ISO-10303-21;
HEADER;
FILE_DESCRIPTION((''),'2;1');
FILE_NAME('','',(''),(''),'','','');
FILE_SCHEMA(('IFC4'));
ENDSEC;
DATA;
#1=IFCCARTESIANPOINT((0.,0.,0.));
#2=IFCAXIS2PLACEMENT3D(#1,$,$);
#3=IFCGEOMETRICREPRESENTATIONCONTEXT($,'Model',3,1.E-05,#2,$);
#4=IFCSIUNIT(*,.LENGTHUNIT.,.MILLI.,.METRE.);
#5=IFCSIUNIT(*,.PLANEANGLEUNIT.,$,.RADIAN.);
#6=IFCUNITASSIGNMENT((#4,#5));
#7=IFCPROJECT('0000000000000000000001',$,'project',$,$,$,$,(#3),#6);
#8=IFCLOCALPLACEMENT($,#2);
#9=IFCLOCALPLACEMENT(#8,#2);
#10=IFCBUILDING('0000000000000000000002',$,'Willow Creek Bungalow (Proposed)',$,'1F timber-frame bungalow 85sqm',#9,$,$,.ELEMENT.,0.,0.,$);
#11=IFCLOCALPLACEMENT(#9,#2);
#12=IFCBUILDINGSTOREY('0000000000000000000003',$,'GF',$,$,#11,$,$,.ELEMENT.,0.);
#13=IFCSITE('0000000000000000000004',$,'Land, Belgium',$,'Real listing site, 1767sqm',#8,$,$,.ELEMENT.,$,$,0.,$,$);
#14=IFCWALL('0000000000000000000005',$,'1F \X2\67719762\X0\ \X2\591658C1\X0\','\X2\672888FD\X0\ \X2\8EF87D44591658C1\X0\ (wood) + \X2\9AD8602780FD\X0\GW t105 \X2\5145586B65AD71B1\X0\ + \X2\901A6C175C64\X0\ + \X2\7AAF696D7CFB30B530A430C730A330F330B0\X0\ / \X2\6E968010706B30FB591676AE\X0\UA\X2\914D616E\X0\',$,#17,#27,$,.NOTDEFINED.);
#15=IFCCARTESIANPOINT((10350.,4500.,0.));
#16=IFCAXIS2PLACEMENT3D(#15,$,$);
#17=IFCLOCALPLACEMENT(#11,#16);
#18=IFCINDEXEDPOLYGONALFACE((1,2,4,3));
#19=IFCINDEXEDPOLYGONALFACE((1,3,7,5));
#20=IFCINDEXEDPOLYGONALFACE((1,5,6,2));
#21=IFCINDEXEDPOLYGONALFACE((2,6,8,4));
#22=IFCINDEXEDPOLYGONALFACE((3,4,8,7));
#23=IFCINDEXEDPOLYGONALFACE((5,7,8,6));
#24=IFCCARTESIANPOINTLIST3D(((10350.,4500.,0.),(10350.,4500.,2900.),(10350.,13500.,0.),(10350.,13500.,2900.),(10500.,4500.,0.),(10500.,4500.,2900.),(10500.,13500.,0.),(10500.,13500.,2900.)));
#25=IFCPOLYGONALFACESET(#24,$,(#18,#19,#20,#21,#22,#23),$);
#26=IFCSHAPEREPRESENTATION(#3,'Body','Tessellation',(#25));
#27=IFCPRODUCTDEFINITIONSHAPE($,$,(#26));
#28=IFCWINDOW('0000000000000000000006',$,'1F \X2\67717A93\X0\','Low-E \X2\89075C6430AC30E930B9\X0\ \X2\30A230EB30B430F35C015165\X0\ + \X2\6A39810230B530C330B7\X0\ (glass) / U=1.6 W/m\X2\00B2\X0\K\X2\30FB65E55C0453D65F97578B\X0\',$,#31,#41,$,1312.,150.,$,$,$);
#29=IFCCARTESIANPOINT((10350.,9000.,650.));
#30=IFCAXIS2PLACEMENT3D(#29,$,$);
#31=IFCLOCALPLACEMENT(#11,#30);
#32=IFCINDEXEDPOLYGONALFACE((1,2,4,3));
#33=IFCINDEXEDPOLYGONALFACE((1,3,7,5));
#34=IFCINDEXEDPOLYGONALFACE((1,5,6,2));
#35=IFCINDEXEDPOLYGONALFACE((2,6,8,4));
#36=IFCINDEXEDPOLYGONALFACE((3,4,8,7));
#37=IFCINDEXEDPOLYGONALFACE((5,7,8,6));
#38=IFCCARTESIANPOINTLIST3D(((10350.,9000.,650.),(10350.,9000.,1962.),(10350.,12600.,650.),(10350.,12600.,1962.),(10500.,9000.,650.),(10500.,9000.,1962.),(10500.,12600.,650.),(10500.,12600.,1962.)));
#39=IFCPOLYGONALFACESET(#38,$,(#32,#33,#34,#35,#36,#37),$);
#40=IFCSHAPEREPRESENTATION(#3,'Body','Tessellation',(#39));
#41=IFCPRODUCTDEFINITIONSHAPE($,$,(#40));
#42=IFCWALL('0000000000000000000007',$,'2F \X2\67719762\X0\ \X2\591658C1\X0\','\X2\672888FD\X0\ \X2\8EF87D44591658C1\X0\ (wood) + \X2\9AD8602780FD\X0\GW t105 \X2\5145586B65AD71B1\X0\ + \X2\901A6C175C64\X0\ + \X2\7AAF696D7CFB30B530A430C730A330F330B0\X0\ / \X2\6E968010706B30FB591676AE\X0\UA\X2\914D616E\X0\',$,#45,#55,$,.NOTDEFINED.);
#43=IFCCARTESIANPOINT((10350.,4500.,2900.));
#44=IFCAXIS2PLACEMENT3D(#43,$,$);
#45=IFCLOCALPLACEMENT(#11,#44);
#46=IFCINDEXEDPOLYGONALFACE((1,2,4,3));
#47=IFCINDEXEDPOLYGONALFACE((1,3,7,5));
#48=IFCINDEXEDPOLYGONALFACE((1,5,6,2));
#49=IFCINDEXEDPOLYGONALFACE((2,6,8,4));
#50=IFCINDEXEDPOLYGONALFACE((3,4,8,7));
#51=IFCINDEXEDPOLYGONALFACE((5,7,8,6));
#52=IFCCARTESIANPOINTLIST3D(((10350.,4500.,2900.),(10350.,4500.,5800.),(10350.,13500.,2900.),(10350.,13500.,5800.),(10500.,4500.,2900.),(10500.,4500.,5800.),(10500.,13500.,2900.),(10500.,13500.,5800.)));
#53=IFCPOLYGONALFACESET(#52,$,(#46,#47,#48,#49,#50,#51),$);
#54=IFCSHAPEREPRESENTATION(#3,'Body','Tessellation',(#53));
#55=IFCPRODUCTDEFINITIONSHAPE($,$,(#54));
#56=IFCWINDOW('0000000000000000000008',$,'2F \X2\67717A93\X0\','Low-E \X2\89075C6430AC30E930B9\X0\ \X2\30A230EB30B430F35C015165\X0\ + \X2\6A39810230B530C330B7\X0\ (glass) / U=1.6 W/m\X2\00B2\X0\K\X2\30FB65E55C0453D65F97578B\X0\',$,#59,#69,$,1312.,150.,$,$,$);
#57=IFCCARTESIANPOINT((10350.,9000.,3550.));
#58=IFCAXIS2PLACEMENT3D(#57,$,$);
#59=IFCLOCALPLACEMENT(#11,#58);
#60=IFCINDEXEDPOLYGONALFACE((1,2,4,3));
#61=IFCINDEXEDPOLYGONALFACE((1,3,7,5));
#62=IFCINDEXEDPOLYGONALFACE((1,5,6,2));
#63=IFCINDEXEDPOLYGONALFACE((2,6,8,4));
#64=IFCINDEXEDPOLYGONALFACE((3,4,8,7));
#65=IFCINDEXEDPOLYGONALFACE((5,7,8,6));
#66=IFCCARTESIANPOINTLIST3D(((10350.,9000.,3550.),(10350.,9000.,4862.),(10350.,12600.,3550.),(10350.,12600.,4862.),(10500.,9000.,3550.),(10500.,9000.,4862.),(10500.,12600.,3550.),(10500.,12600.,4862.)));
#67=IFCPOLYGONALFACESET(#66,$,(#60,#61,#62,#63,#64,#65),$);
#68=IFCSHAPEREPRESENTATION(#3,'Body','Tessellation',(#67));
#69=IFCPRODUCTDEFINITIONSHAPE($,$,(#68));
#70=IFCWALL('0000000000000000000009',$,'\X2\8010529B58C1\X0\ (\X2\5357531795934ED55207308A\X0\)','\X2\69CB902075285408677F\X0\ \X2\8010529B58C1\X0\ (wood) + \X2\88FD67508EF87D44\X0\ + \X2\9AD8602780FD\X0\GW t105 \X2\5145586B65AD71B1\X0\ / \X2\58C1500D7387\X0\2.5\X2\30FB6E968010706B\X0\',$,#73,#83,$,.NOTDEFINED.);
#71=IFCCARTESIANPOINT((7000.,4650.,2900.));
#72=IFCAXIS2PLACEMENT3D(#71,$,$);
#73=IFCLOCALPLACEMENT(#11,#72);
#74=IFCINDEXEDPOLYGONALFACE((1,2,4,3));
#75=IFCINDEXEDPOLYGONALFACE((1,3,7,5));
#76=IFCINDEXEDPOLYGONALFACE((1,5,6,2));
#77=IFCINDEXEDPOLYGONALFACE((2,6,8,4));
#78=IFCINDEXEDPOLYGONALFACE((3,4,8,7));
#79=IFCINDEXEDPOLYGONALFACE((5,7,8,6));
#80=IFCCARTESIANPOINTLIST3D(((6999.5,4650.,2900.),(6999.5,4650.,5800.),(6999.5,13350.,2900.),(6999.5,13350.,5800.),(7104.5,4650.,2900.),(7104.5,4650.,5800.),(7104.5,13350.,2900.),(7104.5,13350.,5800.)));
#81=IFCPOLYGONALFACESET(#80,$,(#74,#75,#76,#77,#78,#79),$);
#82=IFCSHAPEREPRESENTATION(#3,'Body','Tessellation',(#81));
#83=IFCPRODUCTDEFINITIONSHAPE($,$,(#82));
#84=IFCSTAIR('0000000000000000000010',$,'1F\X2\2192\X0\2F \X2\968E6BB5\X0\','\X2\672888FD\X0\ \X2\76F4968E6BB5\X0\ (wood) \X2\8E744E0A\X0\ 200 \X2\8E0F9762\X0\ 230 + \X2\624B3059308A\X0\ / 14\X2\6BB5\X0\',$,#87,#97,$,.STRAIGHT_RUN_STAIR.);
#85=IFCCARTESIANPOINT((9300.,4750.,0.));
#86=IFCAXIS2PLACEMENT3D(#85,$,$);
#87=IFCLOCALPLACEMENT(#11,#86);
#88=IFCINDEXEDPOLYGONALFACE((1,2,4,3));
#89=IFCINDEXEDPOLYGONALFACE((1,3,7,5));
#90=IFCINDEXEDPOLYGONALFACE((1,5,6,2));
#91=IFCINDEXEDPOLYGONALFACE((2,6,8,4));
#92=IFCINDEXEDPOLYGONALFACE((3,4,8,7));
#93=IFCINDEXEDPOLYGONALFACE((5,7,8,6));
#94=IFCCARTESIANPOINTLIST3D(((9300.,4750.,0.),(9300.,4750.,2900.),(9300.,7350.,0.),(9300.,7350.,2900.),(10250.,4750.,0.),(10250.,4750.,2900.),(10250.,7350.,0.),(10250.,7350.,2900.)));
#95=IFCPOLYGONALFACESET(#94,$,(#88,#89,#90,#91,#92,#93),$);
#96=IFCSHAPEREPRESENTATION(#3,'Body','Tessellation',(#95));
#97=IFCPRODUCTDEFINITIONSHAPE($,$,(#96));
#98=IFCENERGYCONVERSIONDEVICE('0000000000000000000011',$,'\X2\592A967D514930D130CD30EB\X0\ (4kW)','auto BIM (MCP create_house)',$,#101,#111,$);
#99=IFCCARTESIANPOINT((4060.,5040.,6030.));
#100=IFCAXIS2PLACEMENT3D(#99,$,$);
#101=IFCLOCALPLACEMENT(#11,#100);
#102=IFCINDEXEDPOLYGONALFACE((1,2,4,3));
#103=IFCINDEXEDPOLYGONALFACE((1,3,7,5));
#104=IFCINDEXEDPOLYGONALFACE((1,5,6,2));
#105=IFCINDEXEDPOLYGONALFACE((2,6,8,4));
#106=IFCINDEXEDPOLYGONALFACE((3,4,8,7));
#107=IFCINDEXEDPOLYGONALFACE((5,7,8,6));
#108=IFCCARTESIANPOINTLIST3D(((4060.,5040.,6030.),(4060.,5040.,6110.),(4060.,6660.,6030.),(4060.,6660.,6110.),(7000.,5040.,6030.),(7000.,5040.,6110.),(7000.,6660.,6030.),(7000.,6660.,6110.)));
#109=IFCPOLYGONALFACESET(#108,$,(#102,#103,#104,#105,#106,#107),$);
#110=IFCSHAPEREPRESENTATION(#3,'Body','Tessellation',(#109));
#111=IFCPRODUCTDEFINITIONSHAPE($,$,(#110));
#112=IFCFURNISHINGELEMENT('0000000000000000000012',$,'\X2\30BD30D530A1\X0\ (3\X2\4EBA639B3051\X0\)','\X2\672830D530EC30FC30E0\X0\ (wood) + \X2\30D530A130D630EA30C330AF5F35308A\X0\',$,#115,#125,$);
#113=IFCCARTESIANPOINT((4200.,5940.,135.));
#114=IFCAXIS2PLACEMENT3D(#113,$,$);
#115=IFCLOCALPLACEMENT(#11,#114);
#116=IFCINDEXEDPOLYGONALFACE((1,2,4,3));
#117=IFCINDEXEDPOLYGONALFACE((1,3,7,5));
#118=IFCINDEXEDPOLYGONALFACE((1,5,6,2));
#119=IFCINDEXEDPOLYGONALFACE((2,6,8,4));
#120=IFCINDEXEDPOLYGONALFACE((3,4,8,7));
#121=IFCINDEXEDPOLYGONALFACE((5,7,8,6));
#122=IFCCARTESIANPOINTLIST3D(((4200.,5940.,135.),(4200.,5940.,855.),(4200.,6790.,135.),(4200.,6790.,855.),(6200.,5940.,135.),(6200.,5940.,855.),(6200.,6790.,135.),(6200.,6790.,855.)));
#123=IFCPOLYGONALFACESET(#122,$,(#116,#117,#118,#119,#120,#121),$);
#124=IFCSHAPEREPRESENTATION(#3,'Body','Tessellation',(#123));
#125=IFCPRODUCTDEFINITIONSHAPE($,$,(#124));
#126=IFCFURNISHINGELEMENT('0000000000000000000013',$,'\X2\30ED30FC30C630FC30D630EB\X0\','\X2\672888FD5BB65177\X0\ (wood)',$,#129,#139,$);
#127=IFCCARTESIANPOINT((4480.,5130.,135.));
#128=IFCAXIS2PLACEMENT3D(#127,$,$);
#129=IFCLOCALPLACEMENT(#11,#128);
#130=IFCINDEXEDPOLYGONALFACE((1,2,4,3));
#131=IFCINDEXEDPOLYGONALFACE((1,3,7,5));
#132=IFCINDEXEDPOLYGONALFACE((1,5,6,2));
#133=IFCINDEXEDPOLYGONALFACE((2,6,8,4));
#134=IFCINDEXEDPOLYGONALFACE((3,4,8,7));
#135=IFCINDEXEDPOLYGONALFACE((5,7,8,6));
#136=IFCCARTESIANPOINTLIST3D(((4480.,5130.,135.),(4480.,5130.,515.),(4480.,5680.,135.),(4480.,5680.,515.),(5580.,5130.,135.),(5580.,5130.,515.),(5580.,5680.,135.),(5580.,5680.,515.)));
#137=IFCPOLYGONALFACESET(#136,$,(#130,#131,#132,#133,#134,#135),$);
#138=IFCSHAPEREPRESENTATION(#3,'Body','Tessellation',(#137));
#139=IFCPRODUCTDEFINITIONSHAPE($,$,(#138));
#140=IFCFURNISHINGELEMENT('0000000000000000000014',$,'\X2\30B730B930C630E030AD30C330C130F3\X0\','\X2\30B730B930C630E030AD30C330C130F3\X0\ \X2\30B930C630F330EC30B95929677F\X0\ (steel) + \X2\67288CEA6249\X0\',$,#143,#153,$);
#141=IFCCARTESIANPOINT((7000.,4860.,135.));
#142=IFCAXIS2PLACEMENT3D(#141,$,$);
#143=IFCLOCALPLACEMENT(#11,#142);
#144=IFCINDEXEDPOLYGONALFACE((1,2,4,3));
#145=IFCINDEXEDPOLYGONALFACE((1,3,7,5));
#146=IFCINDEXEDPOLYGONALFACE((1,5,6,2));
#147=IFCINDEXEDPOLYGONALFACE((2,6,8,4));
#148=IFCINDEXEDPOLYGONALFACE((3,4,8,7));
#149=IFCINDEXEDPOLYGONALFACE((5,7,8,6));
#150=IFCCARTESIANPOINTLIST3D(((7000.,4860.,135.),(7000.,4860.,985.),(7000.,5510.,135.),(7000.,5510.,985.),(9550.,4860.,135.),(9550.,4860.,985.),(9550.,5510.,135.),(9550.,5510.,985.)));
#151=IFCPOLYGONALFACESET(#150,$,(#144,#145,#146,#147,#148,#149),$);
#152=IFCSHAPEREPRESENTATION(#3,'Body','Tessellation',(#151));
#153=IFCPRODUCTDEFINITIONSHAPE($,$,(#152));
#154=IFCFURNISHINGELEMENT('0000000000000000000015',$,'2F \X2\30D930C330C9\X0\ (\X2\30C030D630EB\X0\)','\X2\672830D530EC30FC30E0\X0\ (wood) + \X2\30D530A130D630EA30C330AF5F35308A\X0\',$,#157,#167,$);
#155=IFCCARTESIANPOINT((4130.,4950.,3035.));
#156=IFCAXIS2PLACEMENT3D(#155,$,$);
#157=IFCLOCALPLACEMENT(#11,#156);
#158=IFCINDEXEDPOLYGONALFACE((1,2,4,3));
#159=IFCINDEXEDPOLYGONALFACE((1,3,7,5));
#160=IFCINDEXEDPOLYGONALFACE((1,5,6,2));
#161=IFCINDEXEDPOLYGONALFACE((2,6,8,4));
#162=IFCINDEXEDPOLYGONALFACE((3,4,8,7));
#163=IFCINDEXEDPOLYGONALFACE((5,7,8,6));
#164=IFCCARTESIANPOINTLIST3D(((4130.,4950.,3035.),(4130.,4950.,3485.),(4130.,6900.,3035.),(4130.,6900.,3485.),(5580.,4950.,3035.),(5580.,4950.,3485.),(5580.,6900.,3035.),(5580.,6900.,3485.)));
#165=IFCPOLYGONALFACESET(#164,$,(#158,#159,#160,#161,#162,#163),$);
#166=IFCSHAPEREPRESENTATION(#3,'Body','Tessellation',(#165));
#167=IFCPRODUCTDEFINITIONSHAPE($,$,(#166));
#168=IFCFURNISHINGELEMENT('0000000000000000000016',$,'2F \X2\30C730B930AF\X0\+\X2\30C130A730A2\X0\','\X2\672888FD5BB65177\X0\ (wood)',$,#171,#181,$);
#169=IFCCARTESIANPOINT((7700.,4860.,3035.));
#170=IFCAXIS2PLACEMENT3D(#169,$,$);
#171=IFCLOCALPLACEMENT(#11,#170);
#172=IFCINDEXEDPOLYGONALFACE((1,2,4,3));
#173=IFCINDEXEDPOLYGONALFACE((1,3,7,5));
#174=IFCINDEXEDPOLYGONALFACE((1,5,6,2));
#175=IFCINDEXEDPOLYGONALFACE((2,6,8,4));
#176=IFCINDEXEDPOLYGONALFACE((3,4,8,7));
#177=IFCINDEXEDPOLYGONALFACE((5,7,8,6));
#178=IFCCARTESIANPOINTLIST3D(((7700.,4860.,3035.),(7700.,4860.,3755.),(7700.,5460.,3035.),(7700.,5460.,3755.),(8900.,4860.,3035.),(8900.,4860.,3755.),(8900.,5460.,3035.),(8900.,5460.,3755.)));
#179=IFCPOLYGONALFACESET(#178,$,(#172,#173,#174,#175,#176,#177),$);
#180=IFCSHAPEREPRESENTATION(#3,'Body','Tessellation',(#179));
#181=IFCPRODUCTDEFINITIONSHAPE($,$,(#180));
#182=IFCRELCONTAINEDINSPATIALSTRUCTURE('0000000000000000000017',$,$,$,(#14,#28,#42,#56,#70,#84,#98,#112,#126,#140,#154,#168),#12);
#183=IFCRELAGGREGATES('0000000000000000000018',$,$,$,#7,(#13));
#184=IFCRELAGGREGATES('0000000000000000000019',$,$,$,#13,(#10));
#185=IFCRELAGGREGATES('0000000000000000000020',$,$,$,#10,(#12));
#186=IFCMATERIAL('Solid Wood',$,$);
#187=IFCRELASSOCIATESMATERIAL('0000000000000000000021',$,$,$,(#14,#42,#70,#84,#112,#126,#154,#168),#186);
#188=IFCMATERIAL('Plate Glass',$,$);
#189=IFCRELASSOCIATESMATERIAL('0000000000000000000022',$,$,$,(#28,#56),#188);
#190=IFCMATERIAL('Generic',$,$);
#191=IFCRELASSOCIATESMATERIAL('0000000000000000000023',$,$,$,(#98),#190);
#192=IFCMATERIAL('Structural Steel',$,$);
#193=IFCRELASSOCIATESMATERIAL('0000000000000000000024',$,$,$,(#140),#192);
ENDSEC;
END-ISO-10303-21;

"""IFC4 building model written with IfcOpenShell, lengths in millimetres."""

from ifc_helpers import new_model, si_unit, frame, frame_2d, origin, place, context, project, spatial, rectangle, extrude, material, element, fill, save


model = new_model("IFC4")

# Units and contexts
model_context = context("Model", 3, precision=1e-05, world=origin())
ifc_project = project(units=[si_unit("LENGTHUNIT", "METRE", prefix="MILLI"), si_unit("PLANEANGLEUNIT", "RADIAN")], contexts=[model_context])

# Site, building, storey
site_placement = place(None, origin())
site = spatial("IfcSite", under=ifc_project, at=site_placement, Name="Land, Belgium", ObjectType="Real listing site, 1767sqm", CompositionType="ELEMENT", RefElevation=0.0)
building_placement = place(site_placement, origin())
building = spatial("IfcBuilding", under=site, at=building_placement, Name="Willow Creek Bungalow (Proposed)", ObjectType="1F timber-frame bungalow 85sqm", CompositionType="ELEMENT", ElevationOfRefHeight=0.0, ElevationOfTerrain=0.0)
storey_placement = place(building_placement, origin())
storey = spatial("IfcBuildingStorey", under=building, at=storey_placement, Name="GF", CompositionType="ELEMENT", Elevation=0.0)

# Wall, opening, window
ifc_material_1 = material(Name="Solid Wood")
wall_1_placement = place(storey_placement, frame((10350.0, 4500.0, 0.0)))
wall_1 = element("IfcWall", 1, at=wall_1_placement, inside=storey, material=ifc_material_1, Name="1F 東面 外壁", Description="木製 軸組外壁 (wood) + 高性能GW t105 充填断熱 + 通気層 + 窯業系サイディング / 準耐火・外皮UA配慮", PredefinedType="NOTDEFINED", context=model_context, shape_type="SweptSolid", body=[
    extrude(rectangle(XDim=150.0, YDim=9000.0, at=frame_2d((75.0, 4500.0))), frame((10350.0, 4500.0, 0.0)), (0.0, 0.0, 1.0), 2900.0),
])
opening_1_placement = place(storey_placement, frame((10350.0, 9000.0, 650.0)))
opening_1 = element("IfcOpeningElement", 2, at=opening_1_placement, cuts=wall_1, PredefinedType="NOTDEFINED", context=model_context, shape_type="SweptSolid", body=[
    extrude(rectangle(XDim=150.0, YDim=3600.0, at=frame_2d((75.0, 1800.0))), frame((10350.0, 9000.0, 650.0)), (0.0, 0.0, 1.0), 1312.0),
])
ifc_material_2 = material(Name="Plate Glass")
window_1_placement = place(storey_placement, frame((10350.0, 9000.0, 650.0)))
window_1 = element("IfcWindow", 3, at=window_1_placement, inside=storey, material=ifc_material_2, Name="1F 東窓", Description="Low-E 複層ガラス アルゴン封入 + 樹脂サッシ (glass) / U=1.6 W/m²K・日射取得型", OverallHeight=1312.0, OverallWidth=150.0, context=model_context, shape_type="SweptSolid", body=[
    extrude(rectangle(XDim=150.0, YDim=3600.0, at=frame_2d((75.0, 1800.0))), frame((10350.0, 9000.0, 650.0)), (0.0, 0.0, 1.0), 1312.0),
])
fill(opening_1, window_1)

# Wall, opening, window
wall_2_placement = place(storey_placement, frame((10350.0, 4500.0, 2900.0)))
wall_2 = element("IfcWall", 4, at=wall_2_placement, inside=storey, material=ifc_material_1, Name="2F 東面 外壁", Description="木製 軸組外壁 (wood) + 高性能GW t105 充填断熱 + 通気層 + 窯業系サイディング / 準耐火・外皮UA配慮", PredefinedType="NOTDEFINED", context=model_context, shape_type="SweptSolid", body=[
    extrude(rectangle(XDim=150.0, YDim=9000.0, at=frame_2d((75.0, 4500.0))), frame((10350.0, 4500.0, 2900.0)), (0.0, 0.0, 1.0), 2900.0),
])
opening_2_placement = place(storey_placement, frame((10350.0, 9000.0, 3550.0)))
opening_2 = element("IfcOpeningElement", 5, at=opening_2_placement, cuts=wall_2, PredefinedType="NOTDEFINED", context=model_context, shape_type="SweptSolid", body=[
    extrude(rectangle(XDim=150.0, YDim=3600.0, at=frame_2d((75.0, 1800.0))), frame((10350.0, 9000.0, 3550.0)), (0.0, 0.0, 1.0), 1312.0),
])
window_2_placement = place(storey_placement, frame((10350.0, 9000.0, 3550.0)))
window_2 = element("IfcWindow", 6, at=window_2_placement, inside=storey, material=ifc_material_2, Name="2F 東窓", Description="Low-E 複層ガラス アルゴン封入 + 樹脂サッシ (glass) / U=1.6 W/m²K・日射取得型", OverallHeight=1312.0, OverallWidth=150.0, context=model_context, shape_type="SweptSolid", body=[
    extrude(rectangle(XDim=150.0, YDim=3600.0, at=frame_2d((75.0, 1800.0))), frame((10350.0, 9000.0, 3550.0)), (0.0, 0.0, 1.0), 1312.0),
])
fill(opening_2, window_2)

# Wall
wall_3_placement = place(storey_placement, frame((7000.0, 4650.0, 2900.0)))
element("IfcWall", 7, at=wall_3_placement, inside=storey, material=ifc_material_1, Name="耐力壁 (南北間仕切り)", Description="構造用合板 耐力壁 (wood) + 製材軸組 + 高性能GW t105 充填断熱 / 壁倍率2.5・準耐火", PredefinedType="NOTDEFINED", context=model_context, shape_type="SweptSolid", body=[
    extrude(rectangle(XDim=105.0, YDim=8700.0, at=frame_2d((52.0, 4350.0))), frame((7000.0, 4650.0, 2900.0)), (0.0, 0.0, 1.0), 2900.0),
])

# Stair
stair_placement = place(storey_placement, frame((9300.0, 4750.0, 0.0)))
element("IfcStair", 8, at=stair_placement, inside=storey, material=ifc_material_1, Name="1F→2F 階段", Description="木製 直階段 (wood) 蹴上 200 踏面 230 + 手すり / 14段", PredefinedType="STRAIGHT_RUN_STAIR", context=model_context, shape_type="SweptSolid", body=[
    extrude(rectangle(XDim=950.0, YDim=2600.0, at=frame_2d((475.0, 1300.0))), frame((9300.0, 4750.0, 0.0)), (0.0, 0.0, 1.0), 2900.0),
])

# Energy conversion device
ifc_material_3 = material(Name="Generic")
energy_conversion_device_placement = place(storey_placement, frame((4060.0, 5040.0, 6030.0)))
element("IfcEnergyConversionDevice", 9, at=energy_conversion_device_placement, inside=storey, material=ifc_material_3, Name="太陽光パネル (4kW)", Description="auto BIM (MCP create_house)", context=model_context, shape_type="SweptSolid", body=[
    extrude(rectangle(XDim=2940.0, YDim=1620.0, at=frame_2d((1470.0, 810.0))), frame((4060.0, 5040.0, 6030.0)), (0.0, 0.0, 1.0), 80.0),
])

# Furnishing elements
furnishing_1_placement = place(storey_placement, frame((4200.0, 5940.0, 135.0)))
element("IfcFurnishingElement", 10, at=furnishing_1_placement, inside=storey, material=ifc_material_1, Name="ソファ (3人掛け)", Description="木フレーム (wood) + ファブリック張り", context=model_context, shape_type="SweptSolid", body=[
    extrude(rectangle(XDim=2000.0, YDim=850.0, at=frame_2d((1000.0, 425.0))), frame((4200.0, 5940.0, 135.0)), (0.0, 0.0, 1.0), 720.0),
])
furnishing_2_placement = place(storey_placement, frame((4480.0, 5130.0, 135.0)))
element("IfcFurnishingElement", 11, at=furnishing_2_placement, inside=storey, material=ifc_material_1, Name="ローテーブル", Description="木製家具 (wood)", context=model_context, shape_type="SweptSolid", body=[
    extrude(rectangle(XDim=1100.0, YDim=550.0, at=frame_2d((550.0, 275.0))), frame((4480.0, 5130.0, 135.0)), (0.0, 0.0, 1.0), 380.0),
])
ifc_material_4 = material(Name="Structural Steel")
furnishing_3_placement = place(storey_placement, frame((7000.0, 4860.0, 135.0)))
element("IfcFurnishingElement", 12, at=furnishing_3_placement, inside=storey, material=ifc_material_4, Name="システムキッチン", Description="システムキッチン ステンレス天板 (steel) + 木質扉", context=model_context, shape_type="SweptSolid", body=[
    extrude(rectangle(XDim=2550.0, YDim=650.0, at=frame_2d((1275.0, 325.0))), frame((7000.0, 4860.0, 135.0)), (0.0, 0.0, 1.0), 850.0),
])
furnishing_4_placement = place(storey_placement, frame((4130.0, 4950.0, 3035.0)))
element("IfcFurnishingElement", 13, at=furnishing_4_placement, inside=storey, material=ifc_material_1, Name="2F ベッド (ダブル)", Description="木フレーム (wood) + ファブリック張り", context=model_context, shape_type="SweptSolid", body=[
    extrude(rectangle(XDim=1450.0, YDim=1950.0, at=frame_2d((725.0, 975.0))), frame((4130.0, 4950.0, 3035.0)), (0.0, 0.0, 1.0), 450.0),
])
furnishing_5_placement = place(storey_placement, frame((7700.0, 4860.0, 3035.0)))
element("IfcFurnishingElement", 14, at=furnishing_5_placement, inside=storey, material=ifc_material_1, Name="2F デスク+チェア", Description="木製家具 (wood)", context=model_context, shape_type="SweptSolid", body=[
    extrude(rectangle(XDim=1200.0, YDim=600.0, at=frame_2d((600.0, 300.0))), frame((7700.0, 4860.0, 3035.0)), (0.0, 0.0, 1.0), 720.0),
])

save(model, "model.ifc")
